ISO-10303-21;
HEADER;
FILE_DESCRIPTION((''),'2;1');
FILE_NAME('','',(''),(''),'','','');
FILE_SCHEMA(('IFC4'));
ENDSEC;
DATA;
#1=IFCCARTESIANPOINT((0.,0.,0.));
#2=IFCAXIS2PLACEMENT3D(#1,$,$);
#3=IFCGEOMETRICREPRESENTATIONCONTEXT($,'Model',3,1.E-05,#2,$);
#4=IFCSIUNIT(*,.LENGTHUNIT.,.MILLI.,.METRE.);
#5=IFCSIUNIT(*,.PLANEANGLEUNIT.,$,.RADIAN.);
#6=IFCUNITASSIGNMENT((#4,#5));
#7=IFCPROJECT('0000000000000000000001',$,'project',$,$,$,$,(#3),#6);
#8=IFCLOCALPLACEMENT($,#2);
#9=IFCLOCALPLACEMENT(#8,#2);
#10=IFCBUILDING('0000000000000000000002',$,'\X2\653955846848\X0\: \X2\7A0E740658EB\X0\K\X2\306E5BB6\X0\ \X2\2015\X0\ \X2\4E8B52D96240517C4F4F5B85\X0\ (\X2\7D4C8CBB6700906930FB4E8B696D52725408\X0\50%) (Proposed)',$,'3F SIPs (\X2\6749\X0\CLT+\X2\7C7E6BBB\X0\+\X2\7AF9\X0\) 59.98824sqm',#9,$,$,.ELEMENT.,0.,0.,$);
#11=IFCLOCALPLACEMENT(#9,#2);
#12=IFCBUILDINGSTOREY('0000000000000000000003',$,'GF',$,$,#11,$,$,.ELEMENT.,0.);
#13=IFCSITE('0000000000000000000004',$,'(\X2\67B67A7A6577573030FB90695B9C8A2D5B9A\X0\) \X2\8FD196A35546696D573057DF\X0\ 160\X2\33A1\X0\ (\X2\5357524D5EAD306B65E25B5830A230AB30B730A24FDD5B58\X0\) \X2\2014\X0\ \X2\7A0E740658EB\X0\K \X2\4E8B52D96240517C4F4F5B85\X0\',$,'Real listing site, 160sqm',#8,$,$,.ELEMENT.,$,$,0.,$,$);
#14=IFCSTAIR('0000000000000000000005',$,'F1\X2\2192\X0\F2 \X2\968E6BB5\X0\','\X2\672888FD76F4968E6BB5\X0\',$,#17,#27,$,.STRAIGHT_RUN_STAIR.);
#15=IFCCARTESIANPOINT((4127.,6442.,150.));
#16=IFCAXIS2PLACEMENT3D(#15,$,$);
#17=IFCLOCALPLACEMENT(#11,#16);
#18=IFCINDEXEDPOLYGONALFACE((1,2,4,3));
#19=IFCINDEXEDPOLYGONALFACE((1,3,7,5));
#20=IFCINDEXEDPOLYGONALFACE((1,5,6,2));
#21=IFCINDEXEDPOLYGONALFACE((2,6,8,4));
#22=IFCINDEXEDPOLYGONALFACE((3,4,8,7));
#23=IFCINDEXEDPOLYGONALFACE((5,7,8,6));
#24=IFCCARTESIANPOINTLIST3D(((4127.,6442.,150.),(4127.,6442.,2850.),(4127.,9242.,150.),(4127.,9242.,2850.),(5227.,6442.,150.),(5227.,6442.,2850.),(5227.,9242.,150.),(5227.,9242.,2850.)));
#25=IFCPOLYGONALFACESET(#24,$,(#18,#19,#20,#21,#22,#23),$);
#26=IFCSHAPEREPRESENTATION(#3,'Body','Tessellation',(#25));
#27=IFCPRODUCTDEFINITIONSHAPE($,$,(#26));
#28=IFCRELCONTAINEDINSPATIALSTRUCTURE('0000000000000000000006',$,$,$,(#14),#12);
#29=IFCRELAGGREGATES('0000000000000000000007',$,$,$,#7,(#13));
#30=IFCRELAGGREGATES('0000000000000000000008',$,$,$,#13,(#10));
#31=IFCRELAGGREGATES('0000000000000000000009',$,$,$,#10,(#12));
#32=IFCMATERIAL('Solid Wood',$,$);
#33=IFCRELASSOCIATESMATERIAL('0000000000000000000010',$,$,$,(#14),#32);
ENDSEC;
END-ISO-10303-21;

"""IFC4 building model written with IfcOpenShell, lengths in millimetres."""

from ifc_helpers import new_model, si_unit, frame, frame_2d, origin, place, context, project, spatial, rectangle, extrude, material, element, save


model = new_model("IFC4")

# Units and contexts
model_context = context("Model", 3, precision=1e-05, world=origin())
ifc_project = project(units=[si_unit("LENGTHUNIT", "METRE", prefix="MILLI"), si_unit("PLANEANGLEUNIT", "RADIAN")], contexts=[model_context])

# Site, building, storey
site_placement = place(None, origin())
site = spatial("IfcSite", under=ifc_project, at=site_placement, Name="(架空敷地・適宜設定) 近隣商業地域 160㎡ (南前庭に既存アカシア保存) — 税理士K 事務所兼住宅", ObjectType="Real listing site, 160sqm", CompositionType="ELEMENT", RefElevation=0.0)
building_placement = place(site_placement, origin())
building = spatial("IfcBuilding", under=site, at=building_placement, Name="改善案: 税理士Kの家 ― 事務所兼住宅 (経費最適・事業割合50%) (Proposed)", ObjectType="3F SIPs (杉CLT+籾殻+竹) 59.98824sqm", CompositionType="ELEMENT", ElevationOfRefHeight=0.0, ElevationOfTerrain=0.0)
storey_placement = place(building_placement, origin())
storey = spatial("IfcBuildingStorey", under=building, at=storey_placement, Name="GF", CompositionType="ELEMENT", Elevation=0.0)

# Shared definitions
ifc_material_1 = material(Name="Solid Wood")

# Stair
stair_placement = place(storey_placement, frame((4127.0, 6442.0, 150.0)))
element("IfcStair", 1, at=stair_placement, inside=storey, material=ifc_material_1, Name="F1→F2 階段", Description="木製直階段", PredefinedType="STRAIGHT_RUN_STAIR", context=model_context, shape_type="SweptSolid", body=[
    extrude(rectangle(XDim=1100.0, YDim=2800.0, at=frame_2d((550.0, 1400.0))), frame((4127.0, 6442.0, 150.0)), (0.0, 0.0, 1.0), 2700.0),
])

save(model, "model.ifc")
